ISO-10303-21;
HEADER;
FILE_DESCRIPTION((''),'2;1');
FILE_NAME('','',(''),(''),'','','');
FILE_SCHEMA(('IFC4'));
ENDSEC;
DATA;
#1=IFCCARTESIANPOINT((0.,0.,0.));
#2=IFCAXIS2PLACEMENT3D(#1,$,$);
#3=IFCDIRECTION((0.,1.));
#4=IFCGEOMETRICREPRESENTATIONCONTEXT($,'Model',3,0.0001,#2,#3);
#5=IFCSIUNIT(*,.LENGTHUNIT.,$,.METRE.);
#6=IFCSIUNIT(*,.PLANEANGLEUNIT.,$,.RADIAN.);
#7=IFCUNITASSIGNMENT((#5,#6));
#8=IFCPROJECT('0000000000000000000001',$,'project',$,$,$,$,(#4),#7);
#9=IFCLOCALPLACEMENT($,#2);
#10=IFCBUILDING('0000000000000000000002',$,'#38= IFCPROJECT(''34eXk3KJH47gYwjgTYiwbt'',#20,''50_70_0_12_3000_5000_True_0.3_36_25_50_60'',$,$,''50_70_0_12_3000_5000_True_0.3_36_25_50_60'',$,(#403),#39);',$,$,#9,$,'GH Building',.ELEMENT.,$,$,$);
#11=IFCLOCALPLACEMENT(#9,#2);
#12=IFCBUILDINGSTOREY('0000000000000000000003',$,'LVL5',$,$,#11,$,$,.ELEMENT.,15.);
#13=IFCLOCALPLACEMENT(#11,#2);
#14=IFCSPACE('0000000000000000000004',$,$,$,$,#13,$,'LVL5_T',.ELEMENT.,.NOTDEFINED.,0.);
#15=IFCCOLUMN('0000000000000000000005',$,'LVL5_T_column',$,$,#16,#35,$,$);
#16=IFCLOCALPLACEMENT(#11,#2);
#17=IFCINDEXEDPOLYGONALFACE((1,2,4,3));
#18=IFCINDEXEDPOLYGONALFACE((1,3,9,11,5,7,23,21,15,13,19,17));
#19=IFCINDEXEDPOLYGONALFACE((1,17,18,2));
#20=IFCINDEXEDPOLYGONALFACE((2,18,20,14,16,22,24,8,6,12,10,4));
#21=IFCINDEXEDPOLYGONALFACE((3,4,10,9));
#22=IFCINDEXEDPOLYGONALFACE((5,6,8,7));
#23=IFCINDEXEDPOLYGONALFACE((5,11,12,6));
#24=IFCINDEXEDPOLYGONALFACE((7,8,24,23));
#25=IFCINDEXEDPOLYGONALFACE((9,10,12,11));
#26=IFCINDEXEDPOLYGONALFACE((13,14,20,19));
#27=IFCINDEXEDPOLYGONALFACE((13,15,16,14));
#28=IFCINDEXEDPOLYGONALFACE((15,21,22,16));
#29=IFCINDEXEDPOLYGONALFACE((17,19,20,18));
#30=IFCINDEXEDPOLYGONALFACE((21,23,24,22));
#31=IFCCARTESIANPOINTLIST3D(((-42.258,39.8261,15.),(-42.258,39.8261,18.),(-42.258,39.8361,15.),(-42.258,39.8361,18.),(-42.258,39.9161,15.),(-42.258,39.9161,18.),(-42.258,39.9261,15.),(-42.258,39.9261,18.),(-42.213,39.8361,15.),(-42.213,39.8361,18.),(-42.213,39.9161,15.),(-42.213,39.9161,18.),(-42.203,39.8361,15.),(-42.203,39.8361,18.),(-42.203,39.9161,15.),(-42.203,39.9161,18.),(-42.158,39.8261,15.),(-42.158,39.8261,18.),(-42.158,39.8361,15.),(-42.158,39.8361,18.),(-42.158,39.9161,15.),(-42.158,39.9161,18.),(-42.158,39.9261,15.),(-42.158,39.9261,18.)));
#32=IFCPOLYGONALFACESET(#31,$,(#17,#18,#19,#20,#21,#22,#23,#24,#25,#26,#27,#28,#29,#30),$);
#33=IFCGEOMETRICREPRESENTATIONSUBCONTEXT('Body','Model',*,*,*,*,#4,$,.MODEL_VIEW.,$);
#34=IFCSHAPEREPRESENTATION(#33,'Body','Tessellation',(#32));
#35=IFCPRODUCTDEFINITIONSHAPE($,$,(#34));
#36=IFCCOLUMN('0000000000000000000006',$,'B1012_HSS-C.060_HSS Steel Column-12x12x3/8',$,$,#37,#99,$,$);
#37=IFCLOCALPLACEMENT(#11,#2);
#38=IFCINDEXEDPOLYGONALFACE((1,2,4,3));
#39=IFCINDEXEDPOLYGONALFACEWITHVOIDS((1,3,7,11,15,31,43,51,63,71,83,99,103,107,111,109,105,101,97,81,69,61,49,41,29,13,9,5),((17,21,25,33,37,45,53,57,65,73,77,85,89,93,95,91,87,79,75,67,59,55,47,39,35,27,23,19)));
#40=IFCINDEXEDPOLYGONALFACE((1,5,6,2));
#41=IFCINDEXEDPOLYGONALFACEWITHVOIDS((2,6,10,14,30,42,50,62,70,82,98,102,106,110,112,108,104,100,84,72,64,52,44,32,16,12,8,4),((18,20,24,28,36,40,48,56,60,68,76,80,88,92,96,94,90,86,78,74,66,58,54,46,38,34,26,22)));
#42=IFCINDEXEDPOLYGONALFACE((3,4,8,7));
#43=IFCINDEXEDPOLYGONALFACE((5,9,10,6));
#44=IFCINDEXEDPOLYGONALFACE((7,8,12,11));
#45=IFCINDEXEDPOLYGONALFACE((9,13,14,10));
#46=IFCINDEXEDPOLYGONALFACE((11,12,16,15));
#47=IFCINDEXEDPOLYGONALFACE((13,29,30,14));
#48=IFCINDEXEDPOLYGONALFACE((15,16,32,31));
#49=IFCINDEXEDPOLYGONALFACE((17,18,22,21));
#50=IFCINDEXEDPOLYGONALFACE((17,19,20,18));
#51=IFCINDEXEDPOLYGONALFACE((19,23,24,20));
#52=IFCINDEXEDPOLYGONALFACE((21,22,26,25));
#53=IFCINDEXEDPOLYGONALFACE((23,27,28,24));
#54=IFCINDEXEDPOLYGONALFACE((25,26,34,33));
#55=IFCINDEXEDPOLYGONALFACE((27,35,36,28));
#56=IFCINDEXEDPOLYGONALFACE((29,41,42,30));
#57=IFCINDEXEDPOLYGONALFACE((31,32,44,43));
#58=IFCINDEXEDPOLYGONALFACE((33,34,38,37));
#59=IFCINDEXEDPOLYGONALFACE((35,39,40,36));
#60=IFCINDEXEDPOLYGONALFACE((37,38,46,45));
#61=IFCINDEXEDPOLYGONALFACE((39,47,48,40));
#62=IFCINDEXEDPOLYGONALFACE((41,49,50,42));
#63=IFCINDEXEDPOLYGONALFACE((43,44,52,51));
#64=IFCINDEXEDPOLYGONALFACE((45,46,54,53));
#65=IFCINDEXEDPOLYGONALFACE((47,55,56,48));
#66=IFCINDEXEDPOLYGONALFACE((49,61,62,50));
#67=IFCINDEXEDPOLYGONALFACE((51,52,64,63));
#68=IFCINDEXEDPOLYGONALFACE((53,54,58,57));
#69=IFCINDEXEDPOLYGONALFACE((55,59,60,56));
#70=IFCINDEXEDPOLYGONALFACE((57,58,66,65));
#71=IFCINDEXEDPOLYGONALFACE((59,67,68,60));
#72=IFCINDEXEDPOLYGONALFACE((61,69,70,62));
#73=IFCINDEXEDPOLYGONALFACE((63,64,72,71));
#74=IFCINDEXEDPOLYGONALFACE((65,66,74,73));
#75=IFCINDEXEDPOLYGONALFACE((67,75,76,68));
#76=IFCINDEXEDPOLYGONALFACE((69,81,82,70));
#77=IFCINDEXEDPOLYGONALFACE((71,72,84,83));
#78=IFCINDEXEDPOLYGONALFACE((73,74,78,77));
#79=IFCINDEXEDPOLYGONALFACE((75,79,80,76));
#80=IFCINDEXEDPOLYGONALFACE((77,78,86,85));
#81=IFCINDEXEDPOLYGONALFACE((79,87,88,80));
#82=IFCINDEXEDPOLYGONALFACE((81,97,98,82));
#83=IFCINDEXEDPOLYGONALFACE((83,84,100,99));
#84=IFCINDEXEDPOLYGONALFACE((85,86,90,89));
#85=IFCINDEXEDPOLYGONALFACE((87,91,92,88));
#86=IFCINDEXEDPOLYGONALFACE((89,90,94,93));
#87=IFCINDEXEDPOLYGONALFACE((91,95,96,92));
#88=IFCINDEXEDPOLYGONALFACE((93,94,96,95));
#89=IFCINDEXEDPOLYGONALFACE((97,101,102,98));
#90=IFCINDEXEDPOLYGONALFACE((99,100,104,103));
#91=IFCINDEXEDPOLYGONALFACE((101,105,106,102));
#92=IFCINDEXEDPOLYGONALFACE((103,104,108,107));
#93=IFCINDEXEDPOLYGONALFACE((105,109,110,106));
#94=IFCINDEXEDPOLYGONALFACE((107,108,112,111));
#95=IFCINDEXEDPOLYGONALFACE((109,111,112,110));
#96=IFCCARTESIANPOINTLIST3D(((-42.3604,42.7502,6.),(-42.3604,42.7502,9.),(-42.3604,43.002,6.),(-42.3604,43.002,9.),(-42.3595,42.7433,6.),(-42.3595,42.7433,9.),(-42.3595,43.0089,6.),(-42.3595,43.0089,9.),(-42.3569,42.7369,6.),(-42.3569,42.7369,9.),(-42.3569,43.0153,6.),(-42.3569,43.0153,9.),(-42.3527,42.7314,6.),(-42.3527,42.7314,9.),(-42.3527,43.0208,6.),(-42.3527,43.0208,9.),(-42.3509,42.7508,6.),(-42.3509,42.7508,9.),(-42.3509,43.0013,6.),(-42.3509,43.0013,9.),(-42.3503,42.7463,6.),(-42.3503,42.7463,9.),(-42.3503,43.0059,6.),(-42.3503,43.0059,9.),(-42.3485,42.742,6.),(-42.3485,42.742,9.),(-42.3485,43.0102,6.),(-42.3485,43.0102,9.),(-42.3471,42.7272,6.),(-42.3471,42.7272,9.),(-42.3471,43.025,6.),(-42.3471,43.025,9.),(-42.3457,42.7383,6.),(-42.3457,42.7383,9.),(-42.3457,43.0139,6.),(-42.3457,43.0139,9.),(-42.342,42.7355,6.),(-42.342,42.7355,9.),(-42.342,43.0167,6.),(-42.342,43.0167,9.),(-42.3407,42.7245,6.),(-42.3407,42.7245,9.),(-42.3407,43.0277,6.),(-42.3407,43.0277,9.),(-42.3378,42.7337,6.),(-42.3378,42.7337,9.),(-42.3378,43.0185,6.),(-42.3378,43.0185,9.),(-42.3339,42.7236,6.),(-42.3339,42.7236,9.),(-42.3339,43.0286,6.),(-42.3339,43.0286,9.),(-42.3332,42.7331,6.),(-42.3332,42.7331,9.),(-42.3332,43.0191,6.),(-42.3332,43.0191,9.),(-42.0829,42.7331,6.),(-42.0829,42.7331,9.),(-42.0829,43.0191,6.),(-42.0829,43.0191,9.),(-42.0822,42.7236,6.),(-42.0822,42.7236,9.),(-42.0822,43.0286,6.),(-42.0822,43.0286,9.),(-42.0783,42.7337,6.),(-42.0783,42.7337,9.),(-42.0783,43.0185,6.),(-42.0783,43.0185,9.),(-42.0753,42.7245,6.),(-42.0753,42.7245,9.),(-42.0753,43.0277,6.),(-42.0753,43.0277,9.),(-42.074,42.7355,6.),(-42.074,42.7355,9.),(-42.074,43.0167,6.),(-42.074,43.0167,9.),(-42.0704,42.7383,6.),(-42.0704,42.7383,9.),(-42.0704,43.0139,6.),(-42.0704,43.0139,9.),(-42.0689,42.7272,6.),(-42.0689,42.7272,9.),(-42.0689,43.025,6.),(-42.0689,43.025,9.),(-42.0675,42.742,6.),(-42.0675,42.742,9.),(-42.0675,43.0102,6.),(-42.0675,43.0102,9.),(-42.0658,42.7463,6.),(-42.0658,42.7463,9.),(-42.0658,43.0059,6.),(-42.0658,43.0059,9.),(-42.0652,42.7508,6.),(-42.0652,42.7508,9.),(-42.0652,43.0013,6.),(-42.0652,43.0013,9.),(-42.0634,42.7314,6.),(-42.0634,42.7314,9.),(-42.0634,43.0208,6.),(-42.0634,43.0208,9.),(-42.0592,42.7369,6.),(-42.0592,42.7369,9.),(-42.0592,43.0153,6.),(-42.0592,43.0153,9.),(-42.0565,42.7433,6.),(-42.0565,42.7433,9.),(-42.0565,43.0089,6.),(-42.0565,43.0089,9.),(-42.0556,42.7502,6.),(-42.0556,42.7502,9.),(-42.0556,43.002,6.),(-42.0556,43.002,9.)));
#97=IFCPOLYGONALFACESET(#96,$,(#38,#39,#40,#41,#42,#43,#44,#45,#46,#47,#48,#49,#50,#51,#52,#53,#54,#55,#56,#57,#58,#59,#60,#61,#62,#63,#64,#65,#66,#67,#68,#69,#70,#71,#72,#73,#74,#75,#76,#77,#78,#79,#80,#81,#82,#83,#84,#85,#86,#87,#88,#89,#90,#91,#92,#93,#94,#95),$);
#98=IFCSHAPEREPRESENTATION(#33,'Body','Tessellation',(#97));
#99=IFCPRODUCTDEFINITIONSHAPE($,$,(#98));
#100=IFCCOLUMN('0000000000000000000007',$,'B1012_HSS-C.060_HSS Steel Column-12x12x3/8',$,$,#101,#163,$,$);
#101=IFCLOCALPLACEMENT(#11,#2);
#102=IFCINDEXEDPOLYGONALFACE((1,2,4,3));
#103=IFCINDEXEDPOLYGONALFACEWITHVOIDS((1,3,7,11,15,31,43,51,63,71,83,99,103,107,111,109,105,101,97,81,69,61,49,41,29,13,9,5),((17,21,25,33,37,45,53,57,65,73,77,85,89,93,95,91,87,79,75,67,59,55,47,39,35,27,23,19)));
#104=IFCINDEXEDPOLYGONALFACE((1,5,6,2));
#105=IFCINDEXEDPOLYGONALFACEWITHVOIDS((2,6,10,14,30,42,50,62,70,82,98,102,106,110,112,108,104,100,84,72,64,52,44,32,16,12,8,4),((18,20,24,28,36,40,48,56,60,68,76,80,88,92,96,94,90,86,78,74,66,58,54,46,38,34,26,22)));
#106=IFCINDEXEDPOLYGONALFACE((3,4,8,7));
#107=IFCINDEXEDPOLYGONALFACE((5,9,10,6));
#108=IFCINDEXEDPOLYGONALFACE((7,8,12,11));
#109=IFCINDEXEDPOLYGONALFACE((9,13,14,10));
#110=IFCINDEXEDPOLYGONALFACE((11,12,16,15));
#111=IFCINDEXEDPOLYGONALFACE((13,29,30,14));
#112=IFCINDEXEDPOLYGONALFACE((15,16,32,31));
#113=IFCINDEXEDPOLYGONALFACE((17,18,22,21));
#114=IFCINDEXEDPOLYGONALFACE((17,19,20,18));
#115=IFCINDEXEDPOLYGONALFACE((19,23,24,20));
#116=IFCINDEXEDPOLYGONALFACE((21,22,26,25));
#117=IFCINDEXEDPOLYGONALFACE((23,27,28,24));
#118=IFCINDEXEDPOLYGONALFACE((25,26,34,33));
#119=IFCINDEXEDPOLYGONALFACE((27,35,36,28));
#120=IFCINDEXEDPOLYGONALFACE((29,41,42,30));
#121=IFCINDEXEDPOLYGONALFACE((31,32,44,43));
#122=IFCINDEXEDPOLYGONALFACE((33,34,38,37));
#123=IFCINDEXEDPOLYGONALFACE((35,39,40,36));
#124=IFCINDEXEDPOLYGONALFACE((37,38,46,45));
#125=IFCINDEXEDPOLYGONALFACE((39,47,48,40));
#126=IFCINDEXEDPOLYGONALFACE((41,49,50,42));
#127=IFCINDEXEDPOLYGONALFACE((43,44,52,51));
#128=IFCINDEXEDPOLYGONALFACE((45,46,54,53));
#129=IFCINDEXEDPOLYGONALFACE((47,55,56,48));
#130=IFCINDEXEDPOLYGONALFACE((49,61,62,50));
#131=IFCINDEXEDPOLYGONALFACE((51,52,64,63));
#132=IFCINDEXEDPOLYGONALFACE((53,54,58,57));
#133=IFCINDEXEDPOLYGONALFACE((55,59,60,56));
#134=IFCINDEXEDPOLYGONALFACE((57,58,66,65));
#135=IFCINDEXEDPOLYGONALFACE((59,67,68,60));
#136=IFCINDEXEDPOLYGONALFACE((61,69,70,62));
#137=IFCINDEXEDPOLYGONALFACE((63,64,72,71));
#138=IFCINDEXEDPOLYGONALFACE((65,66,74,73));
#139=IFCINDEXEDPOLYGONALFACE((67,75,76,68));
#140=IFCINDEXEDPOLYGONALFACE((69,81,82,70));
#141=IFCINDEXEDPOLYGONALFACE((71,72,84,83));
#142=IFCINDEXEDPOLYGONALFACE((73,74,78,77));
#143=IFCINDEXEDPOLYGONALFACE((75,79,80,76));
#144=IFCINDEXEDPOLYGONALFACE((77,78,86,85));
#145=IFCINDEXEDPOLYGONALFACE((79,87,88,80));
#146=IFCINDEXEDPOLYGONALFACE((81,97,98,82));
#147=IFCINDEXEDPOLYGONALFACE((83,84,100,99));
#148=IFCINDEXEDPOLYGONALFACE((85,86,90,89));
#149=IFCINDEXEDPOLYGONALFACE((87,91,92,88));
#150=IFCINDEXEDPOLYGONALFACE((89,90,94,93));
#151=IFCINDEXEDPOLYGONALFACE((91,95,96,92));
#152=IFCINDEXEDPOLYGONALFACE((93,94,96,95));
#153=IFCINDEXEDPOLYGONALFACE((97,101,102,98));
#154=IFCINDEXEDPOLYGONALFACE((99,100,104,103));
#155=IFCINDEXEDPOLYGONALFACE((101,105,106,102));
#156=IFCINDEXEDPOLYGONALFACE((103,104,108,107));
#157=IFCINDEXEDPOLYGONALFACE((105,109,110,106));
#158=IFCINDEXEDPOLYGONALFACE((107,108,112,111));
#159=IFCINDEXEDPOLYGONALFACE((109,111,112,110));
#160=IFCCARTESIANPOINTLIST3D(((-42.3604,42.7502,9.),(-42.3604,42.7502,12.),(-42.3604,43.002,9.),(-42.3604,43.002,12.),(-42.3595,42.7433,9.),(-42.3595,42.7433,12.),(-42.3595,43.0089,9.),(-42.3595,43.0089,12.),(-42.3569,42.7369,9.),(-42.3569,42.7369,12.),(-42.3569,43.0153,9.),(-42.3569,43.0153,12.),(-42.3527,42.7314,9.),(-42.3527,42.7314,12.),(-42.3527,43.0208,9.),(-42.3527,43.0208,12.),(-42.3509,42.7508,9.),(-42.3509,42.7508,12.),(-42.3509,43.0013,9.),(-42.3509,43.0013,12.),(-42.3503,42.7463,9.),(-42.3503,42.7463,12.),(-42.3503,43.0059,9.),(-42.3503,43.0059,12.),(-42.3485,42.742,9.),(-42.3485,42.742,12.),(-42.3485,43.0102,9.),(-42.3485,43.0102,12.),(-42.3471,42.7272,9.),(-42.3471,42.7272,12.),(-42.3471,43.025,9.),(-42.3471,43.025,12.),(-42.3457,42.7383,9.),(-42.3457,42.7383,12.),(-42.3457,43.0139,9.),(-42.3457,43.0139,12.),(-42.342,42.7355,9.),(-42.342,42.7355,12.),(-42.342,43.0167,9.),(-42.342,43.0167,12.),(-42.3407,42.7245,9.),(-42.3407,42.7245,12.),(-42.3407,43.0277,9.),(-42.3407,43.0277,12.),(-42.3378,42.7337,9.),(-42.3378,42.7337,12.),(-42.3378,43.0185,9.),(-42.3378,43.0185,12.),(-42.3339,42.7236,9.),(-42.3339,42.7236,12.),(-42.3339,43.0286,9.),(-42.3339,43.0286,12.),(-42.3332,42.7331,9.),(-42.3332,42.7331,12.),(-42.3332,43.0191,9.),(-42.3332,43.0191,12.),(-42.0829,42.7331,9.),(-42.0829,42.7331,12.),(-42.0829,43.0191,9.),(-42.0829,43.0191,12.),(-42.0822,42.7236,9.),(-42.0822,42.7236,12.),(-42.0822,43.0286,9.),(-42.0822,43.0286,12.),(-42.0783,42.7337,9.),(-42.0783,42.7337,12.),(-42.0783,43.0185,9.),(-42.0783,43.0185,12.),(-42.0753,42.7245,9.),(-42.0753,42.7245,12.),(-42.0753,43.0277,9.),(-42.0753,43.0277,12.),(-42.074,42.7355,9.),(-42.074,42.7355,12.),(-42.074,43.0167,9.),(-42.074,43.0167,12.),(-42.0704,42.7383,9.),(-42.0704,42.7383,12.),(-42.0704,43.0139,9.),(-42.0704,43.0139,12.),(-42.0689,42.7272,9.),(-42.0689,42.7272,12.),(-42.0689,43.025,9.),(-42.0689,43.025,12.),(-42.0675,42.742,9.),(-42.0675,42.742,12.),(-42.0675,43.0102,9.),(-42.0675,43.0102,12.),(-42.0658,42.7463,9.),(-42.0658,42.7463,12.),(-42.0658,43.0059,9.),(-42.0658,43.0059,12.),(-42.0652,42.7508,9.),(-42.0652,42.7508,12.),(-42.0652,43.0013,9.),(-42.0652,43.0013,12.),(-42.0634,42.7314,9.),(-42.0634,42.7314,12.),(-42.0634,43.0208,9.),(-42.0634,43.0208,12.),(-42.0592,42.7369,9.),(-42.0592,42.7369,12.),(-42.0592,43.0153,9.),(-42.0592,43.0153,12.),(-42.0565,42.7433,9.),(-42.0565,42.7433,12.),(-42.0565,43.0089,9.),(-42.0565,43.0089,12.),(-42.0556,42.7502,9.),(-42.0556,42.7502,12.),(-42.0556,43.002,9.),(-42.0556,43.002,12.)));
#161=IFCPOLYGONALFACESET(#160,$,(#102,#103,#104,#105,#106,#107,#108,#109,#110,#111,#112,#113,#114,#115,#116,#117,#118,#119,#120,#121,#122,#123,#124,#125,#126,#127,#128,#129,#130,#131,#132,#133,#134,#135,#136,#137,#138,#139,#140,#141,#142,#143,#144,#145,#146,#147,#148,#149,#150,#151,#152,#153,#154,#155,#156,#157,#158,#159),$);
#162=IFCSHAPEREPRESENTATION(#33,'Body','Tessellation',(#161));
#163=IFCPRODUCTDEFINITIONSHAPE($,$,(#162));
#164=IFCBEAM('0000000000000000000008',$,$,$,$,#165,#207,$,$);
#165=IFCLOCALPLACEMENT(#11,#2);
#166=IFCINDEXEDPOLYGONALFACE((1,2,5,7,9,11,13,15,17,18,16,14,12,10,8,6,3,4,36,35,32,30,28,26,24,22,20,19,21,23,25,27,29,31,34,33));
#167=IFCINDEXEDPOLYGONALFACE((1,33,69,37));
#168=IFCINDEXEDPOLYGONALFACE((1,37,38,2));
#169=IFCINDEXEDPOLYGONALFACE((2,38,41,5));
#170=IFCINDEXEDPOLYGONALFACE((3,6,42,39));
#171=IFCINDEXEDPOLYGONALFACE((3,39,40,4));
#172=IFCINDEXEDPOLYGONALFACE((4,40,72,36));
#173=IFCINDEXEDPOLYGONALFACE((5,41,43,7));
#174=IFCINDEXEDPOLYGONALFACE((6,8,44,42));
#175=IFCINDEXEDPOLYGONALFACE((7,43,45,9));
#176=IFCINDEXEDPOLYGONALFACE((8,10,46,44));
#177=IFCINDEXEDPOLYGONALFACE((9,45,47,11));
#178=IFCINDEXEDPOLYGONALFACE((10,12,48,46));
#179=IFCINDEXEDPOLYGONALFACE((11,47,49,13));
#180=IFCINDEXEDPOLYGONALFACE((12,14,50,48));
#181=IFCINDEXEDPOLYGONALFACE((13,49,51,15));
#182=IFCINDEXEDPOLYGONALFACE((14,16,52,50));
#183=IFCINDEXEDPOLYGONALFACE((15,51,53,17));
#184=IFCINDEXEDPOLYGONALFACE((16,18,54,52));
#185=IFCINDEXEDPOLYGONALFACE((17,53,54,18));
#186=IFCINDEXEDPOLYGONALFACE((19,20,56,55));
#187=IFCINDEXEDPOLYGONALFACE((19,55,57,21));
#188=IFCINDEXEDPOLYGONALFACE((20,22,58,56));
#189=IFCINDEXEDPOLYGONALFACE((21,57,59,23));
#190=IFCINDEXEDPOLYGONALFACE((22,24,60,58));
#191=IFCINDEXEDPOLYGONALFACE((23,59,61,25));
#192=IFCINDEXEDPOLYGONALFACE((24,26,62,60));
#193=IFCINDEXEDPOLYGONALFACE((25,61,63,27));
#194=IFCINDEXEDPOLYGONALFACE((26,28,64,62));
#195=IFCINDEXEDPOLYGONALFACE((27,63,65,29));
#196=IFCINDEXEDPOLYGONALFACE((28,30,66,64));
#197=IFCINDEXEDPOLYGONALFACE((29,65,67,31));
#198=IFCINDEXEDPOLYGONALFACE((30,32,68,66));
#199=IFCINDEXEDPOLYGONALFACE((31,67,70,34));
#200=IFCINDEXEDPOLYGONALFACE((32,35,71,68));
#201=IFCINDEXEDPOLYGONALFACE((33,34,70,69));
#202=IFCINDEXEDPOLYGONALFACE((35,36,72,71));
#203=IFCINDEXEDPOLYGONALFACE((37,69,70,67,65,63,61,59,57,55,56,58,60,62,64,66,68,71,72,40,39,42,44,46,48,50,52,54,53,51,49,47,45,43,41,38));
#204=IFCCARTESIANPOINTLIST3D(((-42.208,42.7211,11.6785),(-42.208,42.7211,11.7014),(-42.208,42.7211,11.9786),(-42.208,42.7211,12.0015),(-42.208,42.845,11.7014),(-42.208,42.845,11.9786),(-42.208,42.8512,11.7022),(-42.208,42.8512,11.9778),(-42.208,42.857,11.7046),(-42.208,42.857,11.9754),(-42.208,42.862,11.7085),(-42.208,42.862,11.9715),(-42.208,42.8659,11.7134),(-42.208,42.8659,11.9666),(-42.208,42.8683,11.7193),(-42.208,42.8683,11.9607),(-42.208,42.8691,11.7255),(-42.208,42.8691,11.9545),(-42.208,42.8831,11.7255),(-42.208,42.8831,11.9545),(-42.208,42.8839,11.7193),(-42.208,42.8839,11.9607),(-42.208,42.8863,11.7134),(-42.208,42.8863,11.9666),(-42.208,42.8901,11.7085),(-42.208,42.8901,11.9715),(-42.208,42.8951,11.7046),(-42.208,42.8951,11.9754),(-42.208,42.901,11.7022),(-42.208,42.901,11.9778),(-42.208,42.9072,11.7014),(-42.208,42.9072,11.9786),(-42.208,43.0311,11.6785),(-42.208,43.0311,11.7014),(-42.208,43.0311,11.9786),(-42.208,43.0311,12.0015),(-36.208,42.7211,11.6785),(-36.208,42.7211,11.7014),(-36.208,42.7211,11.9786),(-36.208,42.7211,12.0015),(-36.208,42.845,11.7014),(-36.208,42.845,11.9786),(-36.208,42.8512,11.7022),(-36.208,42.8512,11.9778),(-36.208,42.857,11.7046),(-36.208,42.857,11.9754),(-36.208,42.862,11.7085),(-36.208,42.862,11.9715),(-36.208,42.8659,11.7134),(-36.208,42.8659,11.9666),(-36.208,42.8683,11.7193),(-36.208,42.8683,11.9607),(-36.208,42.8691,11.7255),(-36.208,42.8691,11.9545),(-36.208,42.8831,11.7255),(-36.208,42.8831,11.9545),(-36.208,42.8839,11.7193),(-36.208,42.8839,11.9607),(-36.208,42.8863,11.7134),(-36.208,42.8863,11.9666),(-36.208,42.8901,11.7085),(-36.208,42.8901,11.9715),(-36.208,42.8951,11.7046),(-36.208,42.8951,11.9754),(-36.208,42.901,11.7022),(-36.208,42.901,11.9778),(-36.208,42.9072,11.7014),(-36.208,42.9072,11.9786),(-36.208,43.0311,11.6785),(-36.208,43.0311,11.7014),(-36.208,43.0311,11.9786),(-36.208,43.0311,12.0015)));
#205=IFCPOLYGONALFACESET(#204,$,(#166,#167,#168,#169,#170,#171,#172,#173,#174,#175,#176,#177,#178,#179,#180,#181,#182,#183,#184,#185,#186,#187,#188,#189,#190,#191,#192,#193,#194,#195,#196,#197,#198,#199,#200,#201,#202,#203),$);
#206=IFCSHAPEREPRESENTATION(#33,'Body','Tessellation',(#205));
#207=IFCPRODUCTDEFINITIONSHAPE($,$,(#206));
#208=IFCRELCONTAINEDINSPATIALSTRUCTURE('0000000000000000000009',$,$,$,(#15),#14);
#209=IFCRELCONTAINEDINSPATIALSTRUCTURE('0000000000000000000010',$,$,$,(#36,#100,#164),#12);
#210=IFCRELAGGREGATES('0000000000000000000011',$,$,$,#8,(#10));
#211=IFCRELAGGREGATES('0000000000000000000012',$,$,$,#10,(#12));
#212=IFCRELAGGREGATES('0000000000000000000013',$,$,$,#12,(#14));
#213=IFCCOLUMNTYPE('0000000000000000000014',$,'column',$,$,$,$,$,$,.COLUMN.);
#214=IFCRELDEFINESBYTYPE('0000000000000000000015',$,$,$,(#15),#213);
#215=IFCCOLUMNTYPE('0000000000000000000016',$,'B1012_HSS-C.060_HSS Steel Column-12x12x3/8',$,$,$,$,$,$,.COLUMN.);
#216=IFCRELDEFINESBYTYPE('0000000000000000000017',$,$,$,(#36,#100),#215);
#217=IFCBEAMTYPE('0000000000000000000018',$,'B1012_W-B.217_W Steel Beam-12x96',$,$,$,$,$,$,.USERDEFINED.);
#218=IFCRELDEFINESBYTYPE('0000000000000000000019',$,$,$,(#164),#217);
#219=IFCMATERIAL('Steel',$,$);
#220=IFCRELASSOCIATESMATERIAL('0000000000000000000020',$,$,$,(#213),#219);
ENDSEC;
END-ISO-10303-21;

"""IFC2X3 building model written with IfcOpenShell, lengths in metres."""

from ifc_helpers import new_model, si_unit, direction, frame, origin, origin_2d, place, context, subcontext, project, spatial, hollow_rectangle, i_section, extrude, material, type_object, element, save


model = new_model("IFC2X3")

# Units and contexts
model_context = context("Model", 3, precision=0.0001, world=origin(), true_north=direction((0.0, 1.0)))
body_context = subcontext(model_context, "Body", "Model", "MODEL_VIEW")
ifc_project = project(units=[si_unit("LENGTHUNIT", "METRE"), si_unit("PLANEANGLEUNIT", "RADIAN")], contexts=[model_context])

# Building, storey, space
building_placement = place(None, origin())
building = spatial("IfcBuilding", under=ifc_project, at=building_placement, Name="#38= IFCPROJECT('34eXk3KJH47gYwjgTYiwbt',#20,'50_70_0_12_3000_5000_True_0.3_36_25_50_60',$,$,'50_70_0_12_3000_5000_True_0.3_36_25_50_60',$,(#403),#39);", LongName="GH Building", CompositionType="ELEMENT")
storey_placement = place(building_placement, origin())
storey = spatial("IfcBuildingStorey", under=building, at=storey_placement, Name="LVL5", CompositionType="ELEMENT", Elevation=15.0)
space_1_placement = place(storey_placement, origin())
space_1 = spatial("IfcSpace", under=storey, at=space_1_placement, LongName="LVL5_T", CompositionType="ELEMENT", InteriorOrExteriorSpace="NOTDEFINED", ElevationWithFlooring=0.0)

# Column
ifc_material_1 = material(Name="Steel")
column_type_1 = type_object("IfcColumnType", Name="column", PredefinedType="COLUMN", material=ifc_material_1)
for number, where, name in (
    (1, (-42.208, 39.8761, 15.0), "LVL5_T_column"),
):
    element("IfcColumn", number, at=place(space_1_placement, frame(where)), inside=space_1, type_object=column_type_1, Name=name, context=body_context, shape_type="SweptSolid", body=[
        extrude(i_section(OverallWidth=0.1, OverallDepth=0.1, WebThickness=0.01, FlangeThickness=0.01, at=origin_2d()), origin(), (0.0, 0.0, 1.0), 3.0),
    ])

# Columns
column_type_2 = type_object("IfcColumnType", Name="B1012_HSS-C.060_HSS Steel Column-12x12x3/8", PredefinedType="COLUMN")
for number, where, z_axis, x_axis, name in (
    (2, (-42.208, 42.8761, 9.0), (0.0, 0.0, -1.0), (-1.0, 0.0, 0.0), "B1012_HSS-C.060_HSS Steel Column-12x12x3/8"),
    (3, (-42.208, 42.8761, 12.0), (0.0, 0.0, -1.0), (-1.0, 0.0, 0.0), "B1012_HSS-C.060_HSS Steel Column-12x12x3/8"),
):
    element("IfcColumn", number, at=place(storey_placement, frame(where, z_axis=z_axis, x_axis=x_axis)), inside=storey, type_object=column_type_2, Name=name, context=body_context, shape_type="SweptSolid", body=[
        extrude(hollow_rectangle(XDim=0.3048, YDim=0.305, WallThickness=0.0095, InnerFilletRadius=0.0177, OuterFilletRadius=0.0266, at=origin_2d()), origin(), (0.0, 0.0, 1.0), 3.0),
    ])

# Beam
beam_type = type_object("IfcBeamType", Name="B1012_W-B.217_W Steel Beam-12x96", PredefinedType="USERDEFINED")
beam_1_placement = place(storey_placement, frame((-42.208, 42.8761, 11.84), z_axis=(1.0, 0.0, 0.0), x_axis=(0.0, 1.0, 0.0)))
element("IfcBeam", 4, at=beam_1_placement, inside=storey, type_object=beam_type, context=body_context, shape_type="SweptSolid", body=[
    extrude(i_section(OverallWidth=0.31, OverallDepth=0.323, WebThickness=0.014, FlangeThickness=0.0229, FilletRadius=0.0241, at=origin_2d()), origin(), (0.0, 0.0, 1.0), 6.0),
])

save(model, "model.ifc")
